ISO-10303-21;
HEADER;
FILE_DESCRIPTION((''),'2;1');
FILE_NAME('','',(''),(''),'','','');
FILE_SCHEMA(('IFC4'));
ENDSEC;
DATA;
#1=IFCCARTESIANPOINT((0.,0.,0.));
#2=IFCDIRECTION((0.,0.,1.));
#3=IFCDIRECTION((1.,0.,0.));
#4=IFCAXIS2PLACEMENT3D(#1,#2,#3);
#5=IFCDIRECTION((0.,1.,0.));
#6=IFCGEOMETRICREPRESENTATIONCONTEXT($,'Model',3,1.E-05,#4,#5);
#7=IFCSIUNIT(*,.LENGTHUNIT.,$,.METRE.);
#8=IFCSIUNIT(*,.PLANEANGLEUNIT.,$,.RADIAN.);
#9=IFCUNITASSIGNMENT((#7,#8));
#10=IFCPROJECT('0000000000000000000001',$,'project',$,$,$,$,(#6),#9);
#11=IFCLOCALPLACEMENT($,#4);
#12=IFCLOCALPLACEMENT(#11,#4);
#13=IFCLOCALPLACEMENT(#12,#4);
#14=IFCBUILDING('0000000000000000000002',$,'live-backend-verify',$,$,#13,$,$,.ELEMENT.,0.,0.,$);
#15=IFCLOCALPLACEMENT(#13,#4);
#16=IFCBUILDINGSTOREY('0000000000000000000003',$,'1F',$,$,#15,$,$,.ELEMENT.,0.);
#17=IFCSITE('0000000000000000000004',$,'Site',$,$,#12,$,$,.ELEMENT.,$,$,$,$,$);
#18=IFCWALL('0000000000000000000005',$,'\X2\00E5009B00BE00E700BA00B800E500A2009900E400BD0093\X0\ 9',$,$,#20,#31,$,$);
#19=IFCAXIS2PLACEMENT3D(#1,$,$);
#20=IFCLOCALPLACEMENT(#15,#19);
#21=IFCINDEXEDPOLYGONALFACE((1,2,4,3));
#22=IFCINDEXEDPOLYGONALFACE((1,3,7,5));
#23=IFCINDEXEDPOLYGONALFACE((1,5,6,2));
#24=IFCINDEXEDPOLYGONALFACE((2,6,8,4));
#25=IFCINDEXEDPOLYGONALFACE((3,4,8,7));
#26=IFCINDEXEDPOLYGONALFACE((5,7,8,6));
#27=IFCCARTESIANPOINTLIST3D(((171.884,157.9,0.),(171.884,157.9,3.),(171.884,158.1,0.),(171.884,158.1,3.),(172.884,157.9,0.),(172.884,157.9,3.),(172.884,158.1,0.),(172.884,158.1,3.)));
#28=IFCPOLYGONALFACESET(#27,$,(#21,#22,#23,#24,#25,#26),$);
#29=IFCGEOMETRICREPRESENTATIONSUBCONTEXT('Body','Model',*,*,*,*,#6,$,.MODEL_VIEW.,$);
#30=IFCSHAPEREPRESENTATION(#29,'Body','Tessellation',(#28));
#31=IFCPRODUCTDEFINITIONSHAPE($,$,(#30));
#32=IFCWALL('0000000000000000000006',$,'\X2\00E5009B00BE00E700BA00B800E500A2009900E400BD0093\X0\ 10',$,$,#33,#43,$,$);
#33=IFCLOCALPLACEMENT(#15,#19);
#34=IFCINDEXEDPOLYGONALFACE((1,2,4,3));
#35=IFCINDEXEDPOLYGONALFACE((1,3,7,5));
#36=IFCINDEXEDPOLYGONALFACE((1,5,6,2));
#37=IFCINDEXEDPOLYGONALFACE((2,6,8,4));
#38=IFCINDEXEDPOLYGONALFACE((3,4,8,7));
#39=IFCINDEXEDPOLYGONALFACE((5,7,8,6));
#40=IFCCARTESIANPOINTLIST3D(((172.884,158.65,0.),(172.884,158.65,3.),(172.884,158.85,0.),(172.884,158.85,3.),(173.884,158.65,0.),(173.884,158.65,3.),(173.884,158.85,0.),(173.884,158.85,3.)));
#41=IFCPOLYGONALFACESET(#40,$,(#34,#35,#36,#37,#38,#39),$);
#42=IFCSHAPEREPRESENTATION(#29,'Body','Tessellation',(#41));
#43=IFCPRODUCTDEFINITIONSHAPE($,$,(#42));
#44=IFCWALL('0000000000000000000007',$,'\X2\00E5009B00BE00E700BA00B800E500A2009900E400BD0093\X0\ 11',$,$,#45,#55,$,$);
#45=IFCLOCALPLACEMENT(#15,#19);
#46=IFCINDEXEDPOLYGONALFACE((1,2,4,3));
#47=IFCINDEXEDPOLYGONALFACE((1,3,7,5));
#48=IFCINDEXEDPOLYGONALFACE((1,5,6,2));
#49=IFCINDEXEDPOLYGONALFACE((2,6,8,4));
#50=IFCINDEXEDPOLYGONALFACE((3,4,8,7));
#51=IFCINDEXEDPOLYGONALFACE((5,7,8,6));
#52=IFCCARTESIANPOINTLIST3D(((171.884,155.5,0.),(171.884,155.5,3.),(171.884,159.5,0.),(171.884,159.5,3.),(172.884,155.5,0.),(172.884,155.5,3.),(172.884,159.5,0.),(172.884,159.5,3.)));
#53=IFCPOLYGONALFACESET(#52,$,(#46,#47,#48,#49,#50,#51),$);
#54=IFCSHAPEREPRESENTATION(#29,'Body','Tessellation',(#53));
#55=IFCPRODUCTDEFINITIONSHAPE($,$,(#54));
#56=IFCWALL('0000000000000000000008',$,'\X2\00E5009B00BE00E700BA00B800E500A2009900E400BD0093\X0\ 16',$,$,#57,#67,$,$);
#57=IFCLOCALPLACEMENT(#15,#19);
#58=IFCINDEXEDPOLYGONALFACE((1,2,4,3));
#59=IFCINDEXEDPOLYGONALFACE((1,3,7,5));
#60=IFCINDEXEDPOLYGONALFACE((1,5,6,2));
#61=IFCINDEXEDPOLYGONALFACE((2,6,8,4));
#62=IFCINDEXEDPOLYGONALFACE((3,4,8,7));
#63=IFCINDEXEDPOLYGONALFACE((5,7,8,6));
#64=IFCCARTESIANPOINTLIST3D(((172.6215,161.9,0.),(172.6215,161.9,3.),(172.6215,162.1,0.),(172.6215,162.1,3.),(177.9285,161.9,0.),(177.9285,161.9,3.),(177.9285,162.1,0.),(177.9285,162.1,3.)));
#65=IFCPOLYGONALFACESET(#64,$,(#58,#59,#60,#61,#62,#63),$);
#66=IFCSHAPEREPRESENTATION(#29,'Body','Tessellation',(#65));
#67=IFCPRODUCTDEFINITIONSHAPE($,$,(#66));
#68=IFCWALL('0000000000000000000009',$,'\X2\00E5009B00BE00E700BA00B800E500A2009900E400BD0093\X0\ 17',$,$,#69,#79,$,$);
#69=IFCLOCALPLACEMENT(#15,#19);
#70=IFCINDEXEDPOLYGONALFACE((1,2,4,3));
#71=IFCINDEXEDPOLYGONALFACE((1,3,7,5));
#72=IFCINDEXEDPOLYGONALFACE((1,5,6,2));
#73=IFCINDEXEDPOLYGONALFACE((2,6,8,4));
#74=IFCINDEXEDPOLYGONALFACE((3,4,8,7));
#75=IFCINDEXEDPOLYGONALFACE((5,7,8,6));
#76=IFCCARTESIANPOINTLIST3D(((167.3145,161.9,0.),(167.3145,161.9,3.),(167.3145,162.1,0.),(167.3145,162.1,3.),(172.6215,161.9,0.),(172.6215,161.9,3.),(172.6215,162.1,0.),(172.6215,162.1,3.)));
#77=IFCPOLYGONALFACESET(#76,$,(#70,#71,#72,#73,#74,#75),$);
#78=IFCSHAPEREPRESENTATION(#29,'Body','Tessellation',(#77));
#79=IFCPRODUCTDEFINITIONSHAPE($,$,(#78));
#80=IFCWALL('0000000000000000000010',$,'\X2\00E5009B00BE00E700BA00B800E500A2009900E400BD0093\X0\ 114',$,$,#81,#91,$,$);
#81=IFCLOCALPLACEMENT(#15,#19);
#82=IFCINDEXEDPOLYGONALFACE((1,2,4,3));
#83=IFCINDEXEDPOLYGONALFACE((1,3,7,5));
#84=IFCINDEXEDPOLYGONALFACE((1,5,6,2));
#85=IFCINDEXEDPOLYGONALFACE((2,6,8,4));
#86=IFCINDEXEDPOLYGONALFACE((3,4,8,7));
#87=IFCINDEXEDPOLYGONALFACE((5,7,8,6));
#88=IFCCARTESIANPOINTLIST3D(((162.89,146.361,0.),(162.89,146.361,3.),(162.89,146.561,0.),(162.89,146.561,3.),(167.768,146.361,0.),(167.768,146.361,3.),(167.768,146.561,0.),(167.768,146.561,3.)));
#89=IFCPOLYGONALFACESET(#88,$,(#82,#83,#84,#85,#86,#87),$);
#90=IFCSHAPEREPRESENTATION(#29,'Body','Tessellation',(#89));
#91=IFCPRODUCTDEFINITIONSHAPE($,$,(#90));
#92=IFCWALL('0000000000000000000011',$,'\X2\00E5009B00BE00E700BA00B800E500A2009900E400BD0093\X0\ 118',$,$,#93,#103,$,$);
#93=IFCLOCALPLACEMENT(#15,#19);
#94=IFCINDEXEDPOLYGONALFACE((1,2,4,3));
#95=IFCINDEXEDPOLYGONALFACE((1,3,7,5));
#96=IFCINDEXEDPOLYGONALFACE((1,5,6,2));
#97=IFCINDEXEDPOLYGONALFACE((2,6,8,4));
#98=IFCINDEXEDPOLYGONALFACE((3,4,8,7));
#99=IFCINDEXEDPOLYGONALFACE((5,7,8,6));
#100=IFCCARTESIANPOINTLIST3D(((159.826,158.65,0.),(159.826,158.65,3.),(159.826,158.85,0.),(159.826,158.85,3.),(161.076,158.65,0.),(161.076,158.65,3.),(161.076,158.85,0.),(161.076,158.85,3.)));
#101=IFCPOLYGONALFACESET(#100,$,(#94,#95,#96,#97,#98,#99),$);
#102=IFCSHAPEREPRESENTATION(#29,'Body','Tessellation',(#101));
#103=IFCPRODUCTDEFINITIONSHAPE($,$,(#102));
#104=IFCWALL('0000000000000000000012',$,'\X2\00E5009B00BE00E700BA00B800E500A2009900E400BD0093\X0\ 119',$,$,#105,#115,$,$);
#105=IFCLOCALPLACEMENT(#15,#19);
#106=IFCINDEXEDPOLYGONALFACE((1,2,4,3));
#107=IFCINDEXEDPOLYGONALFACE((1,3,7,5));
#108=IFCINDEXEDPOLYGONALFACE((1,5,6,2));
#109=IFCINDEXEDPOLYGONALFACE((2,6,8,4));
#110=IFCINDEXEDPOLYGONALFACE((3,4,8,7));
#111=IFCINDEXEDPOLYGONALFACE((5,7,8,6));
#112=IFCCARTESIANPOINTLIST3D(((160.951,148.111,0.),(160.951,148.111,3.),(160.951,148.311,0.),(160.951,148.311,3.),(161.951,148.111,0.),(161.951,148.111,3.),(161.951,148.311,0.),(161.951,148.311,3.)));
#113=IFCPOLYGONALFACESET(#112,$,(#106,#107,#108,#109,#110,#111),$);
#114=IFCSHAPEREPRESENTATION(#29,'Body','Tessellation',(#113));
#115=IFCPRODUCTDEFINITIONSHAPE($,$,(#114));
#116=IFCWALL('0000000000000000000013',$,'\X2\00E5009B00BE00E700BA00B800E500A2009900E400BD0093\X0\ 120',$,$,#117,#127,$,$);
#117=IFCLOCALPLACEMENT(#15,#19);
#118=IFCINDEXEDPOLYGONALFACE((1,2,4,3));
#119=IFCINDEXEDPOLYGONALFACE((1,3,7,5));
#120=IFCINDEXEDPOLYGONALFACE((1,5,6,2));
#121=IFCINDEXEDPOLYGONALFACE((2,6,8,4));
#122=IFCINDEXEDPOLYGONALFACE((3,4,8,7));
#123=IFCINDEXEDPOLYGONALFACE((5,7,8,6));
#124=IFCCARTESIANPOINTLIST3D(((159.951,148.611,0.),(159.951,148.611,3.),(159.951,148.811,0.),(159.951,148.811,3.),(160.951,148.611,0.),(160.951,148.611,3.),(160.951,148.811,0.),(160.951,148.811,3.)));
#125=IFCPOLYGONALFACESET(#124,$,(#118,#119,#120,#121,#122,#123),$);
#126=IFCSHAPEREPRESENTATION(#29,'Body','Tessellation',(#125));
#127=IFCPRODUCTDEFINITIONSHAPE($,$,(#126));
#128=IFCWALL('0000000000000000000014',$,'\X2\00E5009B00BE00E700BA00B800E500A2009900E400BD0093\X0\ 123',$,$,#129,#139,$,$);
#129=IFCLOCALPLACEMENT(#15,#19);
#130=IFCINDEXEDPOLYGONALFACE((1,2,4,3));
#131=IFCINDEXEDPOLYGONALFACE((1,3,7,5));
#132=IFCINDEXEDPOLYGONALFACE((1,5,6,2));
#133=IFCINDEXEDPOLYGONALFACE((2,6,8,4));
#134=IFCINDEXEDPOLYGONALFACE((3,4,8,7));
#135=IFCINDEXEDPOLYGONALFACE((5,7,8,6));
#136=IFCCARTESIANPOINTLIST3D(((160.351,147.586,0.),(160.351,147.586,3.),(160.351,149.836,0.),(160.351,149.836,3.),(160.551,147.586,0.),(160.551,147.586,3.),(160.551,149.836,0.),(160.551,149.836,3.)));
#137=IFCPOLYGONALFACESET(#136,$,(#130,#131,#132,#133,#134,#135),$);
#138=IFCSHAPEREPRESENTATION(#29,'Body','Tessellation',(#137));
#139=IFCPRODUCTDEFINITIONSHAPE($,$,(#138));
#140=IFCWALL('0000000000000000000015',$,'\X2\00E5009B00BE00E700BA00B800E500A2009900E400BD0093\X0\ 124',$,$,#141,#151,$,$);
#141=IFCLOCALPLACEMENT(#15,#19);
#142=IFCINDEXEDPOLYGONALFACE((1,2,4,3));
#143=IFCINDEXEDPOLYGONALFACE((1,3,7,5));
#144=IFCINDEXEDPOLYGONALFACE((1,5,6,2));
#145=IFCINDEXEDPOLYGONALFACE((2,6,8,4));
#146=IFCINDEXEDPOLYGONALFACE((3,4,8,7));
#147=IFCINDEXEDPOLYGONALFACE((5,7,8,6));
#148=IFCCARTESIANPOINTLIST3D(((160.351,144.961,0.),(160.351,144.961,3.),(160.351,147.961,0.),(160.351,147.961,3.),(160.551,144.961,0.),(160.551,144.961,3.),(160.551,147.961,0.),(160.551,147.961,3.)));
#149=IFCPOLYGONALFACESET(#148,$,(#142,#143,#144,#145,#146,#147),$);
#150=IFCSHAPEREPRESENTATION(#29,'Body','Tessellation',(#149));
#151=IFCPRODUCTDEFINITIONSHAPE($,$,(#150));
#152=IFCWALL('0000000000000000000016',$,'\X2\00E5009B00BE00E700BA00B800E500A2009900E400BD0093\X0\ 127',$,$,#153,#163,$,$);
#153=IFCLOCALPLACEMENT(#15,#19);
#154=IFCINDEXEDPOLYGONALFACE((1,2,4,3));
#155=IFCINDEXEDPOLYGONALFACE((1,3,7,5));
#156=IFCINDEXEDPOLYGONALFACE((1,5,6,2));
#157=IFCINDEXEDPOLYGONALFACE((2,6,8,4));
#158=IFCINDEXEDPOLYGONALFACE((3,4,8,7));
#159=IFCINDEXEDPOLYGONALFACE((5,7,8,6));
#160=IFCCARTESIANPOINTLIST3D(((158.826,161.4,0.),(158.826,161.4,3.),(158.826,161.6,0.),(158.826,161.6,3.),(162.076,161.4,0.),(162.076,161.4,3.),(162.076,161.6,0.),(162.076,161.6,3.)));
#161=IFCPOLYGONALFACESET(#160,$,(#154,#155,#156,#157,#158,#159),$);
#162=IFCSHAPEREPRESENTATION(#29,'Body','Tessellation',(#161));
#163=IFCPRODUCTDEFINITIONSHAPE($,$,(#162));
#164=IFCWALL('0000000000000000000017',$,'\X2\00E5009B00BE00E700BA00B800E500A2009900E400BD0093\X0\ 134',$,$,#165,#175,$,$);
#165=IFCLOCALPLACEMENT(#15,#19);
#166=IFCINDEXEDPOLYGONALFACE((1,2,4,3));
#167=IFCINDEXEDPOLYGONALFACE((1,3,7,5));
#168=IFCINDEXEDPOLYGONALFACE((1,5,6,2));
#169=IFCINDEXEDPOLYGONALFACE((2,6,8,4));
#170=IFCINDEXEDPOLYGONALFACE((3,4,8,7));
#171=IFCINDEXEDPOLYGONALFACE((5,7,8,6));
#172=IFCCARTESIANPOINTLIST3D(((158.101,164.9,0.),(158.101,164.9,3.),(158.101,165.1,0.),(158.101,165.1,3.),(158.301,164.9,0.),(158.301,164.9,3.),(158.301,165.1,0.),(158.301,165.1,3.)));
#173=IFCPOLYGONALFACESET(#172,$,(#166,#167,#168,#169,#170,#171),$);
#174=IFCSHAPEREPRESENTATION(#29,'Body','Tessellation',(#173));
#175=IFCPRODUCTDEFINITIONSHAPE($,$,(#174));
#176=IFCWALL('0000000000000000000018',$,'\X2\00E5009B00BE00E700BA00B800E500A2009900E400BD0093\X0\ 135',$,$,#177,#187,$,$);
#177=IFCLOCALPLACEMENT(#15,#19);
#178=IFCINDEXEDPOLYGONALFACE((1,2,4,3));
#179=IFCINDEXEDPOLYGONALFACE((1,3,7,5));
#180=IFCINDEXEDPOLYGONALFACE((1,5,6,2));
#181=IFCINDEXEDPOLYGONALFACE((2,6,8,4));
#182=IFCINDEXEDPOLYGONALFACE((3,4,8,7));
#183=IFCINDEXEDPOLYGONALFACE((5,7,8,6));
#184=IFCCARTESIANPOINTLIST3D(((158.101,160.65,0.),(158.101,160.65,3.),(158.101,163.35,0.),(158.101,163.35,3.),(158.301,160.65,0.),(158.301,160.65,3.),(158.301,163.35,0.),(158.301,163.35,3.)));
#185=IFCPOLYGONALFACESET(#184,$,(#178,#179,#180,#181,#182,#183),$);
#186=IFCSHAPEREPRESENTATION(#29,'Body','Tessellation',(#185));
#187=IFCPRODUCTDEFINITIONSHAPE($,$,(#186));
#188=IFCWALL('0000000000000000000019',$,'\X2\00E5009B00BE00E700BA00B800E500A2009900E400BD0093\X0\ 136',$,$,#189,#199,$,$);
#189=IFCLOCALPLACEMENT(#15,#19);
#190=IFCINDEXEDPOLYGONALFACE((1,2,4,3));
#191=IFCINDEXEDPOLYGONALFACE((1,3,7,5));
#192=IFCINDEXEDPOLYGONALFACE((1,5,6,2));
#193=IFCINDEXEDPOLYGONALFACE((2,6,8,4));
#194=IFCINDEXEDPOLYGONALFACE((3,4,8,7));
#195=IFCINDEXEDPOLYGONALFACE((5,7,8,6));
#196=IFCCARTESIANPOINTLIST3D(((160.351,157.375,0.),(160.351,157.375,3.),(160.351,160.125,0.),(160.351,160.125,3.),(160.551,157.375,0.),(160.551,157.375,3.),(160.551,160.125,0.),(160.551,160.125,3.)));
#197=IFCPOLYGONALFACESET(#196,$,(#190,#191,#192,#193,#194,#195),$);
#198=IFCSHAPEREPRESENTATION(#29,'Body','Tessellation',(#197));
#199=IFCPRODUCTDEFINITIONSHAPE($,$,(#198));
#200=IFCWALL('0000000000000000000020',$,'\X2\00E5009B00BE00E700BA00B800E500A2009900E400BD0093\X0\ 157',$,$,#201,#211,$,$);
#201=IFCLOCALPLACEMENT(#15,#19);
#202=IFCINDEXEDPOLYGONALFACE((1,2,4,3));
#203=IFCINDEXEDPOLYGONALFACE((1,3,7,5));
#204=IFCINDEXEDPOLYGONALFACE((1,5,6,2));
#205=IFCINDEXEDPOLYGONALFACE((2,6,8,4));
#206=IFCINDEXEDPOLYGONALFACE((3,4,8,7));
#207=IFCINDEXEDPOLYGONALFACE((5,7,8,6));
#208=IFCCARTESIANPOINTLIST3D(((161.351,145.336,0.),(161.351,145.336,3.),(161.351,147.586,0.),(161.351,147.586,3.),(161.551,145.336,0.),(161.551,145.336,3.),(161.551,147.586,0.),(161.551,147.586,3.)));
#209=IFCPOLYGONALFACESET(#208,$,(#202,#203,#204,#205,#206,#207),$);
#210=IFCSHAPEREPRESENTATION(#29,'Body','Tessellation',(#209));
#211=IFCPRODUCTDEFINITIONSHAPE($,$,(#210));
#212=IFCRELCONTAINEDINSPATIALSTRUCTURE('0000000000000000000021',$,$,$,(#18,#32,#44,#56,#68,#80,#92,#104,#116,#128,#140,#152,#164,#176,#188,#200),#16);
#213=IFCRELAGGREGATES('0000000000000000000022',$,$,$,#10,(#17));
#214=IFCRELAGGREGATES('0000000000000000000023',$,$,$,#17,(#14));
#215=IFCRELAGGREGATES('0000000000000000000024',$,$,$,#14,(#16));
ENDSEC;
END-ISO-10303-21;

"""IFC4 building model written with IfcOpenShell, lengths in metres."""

from ifc_helpers import new_model, si_unit, direction, frame, frame_2d, origin_with_axes, place, context, subcontext, project, spatial, rectangle, extrude, element, save


model = new_model("IFC4")

# Units and contexts
model_context = context("Model", 3, precision=1e-05, world=origin_with_axes(), true_north=direction((0.0, 1.0, 0.0)))
body_context = subcontext(model_context, "Body", "Model", "MODEL_VIEW")
ifc_project = project(units=[si_unit("LENGTHUNIT", "METRE"), si_unit("PLANEANGLEUNIT", "RADIAN")], contexts=[model_context])

# Site, building, storey
placement = place(None, origin_with_axes())
site_placement = place(placement, origin_with_axes())
site = spatial("IfcSite", under=ifc_project, at=site_placement, Name="Site", CompositionType="ELEMENT")
building_placement = place(site_placement, origin_with_axes())
building = spatial("IfcBuilding", under=site, at=building_placement, Name="live-backend-verify", CompositionType="ELEMENT", ElevationOfRefHeight=0.0, ElevationOfTerrain=0.0)
storey_placement = place(building_placement, origin_with_axes())
storey = spatial("IfcBuildingStorey", under=building, at=storey_placement, Name="1F", CompositionType="ELEMENT", Elevation=0.0)

# Walls
for number, where, z_axis, x_axis, name in (
    (1, (172.384, 158.0, 0.0), (0.0, 0.0, 1.0), (1.0, 0.0, 0.0), "å\u009b¾çº¸å¢\u0099ä½\u0093 9"),
    (2, (173.384, 158.75, 0.0), (0.0, 0.0, 1.0), (-1.0, 0.0, 0.0), "å\u009b¾çº¸å¢\u0099ä½\u0093 10"),
):
    element("IfcWall", number, at=place(storey_placement, frame(where, z_axis=z_axis, x_axis=x_axis)), inside=storey, Name=name, context=body_context, shape_type="SweptSolid", body=[
        extrude(rectangle(XDim=1.0, YDim=0.2, at=frame_2d((0.0, 0.0), x_axis=(1.0, 0.0, 0.0))), frame((0.0, 0.0, 0.0), z_axis=(0.0, 0.0, 1.0)), (0.0, 0.0, 1.0), 3.0),
    ])
wall_1_placement = place(storey_placement, frame((172.384, 157.5, 0.0), z_axis=(0.0, 0.0, 1.0), x_axis=(1.0, 0.0, 0.0)))
element("IfcWall", 3, at=wall_1_placement, inside=storey, Name="å\u009b¾çº¸å¢\u0099ä½\u0093 11", context=body_context, shape_type="SweptSolid", body=[
    extrude(rectangle(XDim=1.0, YDim=4.0, at=frame_2d((0.0, 0.0), x_axis=(1.0, 0.0, 0.0))), frame((0.0, 0.0, 0.0), z_axis=(0.0, 0.0, 1.0)), (0.0, 0.0, 1.0), 3.0),
])
for number, where, z_axis, x_axis, name in (
    (4, (175.275, 162.0, 0.0), (0.0, 0.0, 1.0), (-1.0, 0.0, 0.0), "å\u009b¾çº¸å¢\u0099ä½\u0093 16"),
    (5, (169.968, 162.0, 0.0), (0.0, 0.0, 1.0), (1.0, 0.0, 0.0), "å\u009b¾çº¸å¢\u0099ä½\u0093 17"),
):
    element("IfcWall", number, at=place(storey_placement, frame(where, z_axis=z_axis, x_axis=x_axis)), inside=storey, Name=name, context=body_context, shape_type="SweptSolid", body=[
        extrude(rectangle(XDim=5.307, YDim=0.2, at=frame_2d((0.0, 0.0), x_axis=(1.0, 0.0, 0.0))), frame((0.0, 0.0, 0.0), z_axis=(0.0, 0.0, 1.0)), (0.0, 0.0, 1.0), 3.0),
    ])
wall_2_placement = place(storey_placement, frame((165.329, 146.461, 0.0), z_axis=(0.0, 0.0, 1.0), x_axis=(-1.0, 0.0, 0.0)))
element("IfcWall", 6, at=wall_2_placement, inside=storey, Name="å\u009b¾çº¸å¢\u0099ä½\u0093 114", context=body_context, shape_type="SweptSolid", body=[
    extrude(rectangle(XDim=4.878, YDim=0.2, at=frame_2d((0.0, 0.0), x_axis=(1.0, 0.0, 0.0))), frame((0.0, 0.0, 0.0), z_axis=(0.0, 0.0, 1.0)), (0.0, 0.0, 1.0), 3.0),
])
wall_3_placement = place(storey_placement, frame((160.451, 158.75, 0.0), z_axis=(0.0, 0.0, 1.0), x_axis=(1.0, 0.0, 0.0)))
element("IfcWall", 7, at=wall_3_placement, inside=storey, Name="å\u009b¾çº¸å¢\u0099ä½\u0093 118", context=body_context, shape_type="SweptSolid", body=[
    extrude(rectangle(XDim=1.25, YDim=0.2, at=frame_2d((0.0, 0.0), x_axis=(1.0, 0.0, 0.0))), frame((0.0, 0.0, 0.0), z_axis=(0.0, 0.0, 1.0)), (0.0, 0.0, 1.0), 3.0),
])
for number, where, z_axis, x_axis, name in (
    (8, (161.451, 148.211, 0.0), (0.0, 0.0, 1.0), (-1.0, 0.0, 0.0), "å\u009b¾çº¸å¢\u0099ä½\u0093 119"),
    (9, (160.451, 148.711, 0.0), (0.0, 0.0, 1.0), (1.0, 0.0, 0.0), "å\u009b¾çº¸å¢\u0099ä½\u0093 120"),
):
    element("IfcWall", number, at=place(storey_placement, frame(where, z_axis=z_axis, x_axis=x_axis)), inside=storey, Name=name, context=body_context, shape_type="SweptSolid", body=[
        extrude(rectangle(XDim=1.0, YDim=0.2, at=frame_2d((0.0, 0.0), x_axis=(1.0, 0.0, 0.0))), frame((0.0, 0.0, 0.0), z_axis=(0.0, 0.0, 1.0)), (0.0, 0.0, 1.0), 3.0),
    ])
wall_4_placement = place(storey_placement, frame((160.451, 148.711, 0.0), z_axis=(0.0, 0.0, 1.0), x_axis=(0.0, -1.0, 0.0)))
element("IfcWall", 10, at=wall_4_placement, inside=storey, Name="å\u009b¾çº¸å¢\u0099ä½\u0093 123", context=body_context, shape_type="SweptSolid", body=[
    extrude(rectangle(XDim=2.25, YDim=0.2, at=frame_2d((0.0, 0.0), x_axis=(1.0, 0.0, 0.0))), frame((0.0, 0.0, 0.0), z_axis=(0.0, 0.0, 1.0)), (0.0, 0.0, 1.0), 3.0),
])
wall_5_placement = place(storey_placement, frame((160.451, 146.461, 0.0), z_axis=(0.0, 0.0, 1.0), x_axis=(0.0, -1.0, 0.0)))
element("IfcWall", 11, at=wall_5_placement, inside=storey, Name="å\u009b¾çº¸å¢\u0099ä½\u0093 124", context=body_context, shape_type="SweptSolid", body=[
    extrude(rectangle(XDim=3.0, YDim=0.2, at=frame_2d((0.0, 0.0), x_axis=(1.0, 0.0, 0.0))), frame((0.0, 0.0, 0.0), z_axis=(0.0, 0.0, 1.0)), (0.0, 0.0, 1.0), 3.0),
])
wall_6_placement = place(storey_placement, frame((160.451, 161.5, 0.0), z_axis=(0.0, 0.0, 1.0), x_axis=(-1.0, 0.0, 0.0)))
element("IfcWall", 12, at=wall_6_placement, inside=storey, Name="å\u009b¾çº¸å¢\u0099ä½\u0093 127", context=body_context, shape_type="SweptSolid", body=[
    extrude(rectangle(XDim=3.25, YDim=0.2, at=frame_2d((0.0, 0.0), x_axis=(1.0, 0.0, 0.0))), frame((0.0, 0.0, 0.0), z_axis=(0.0, 0.0, 1.0)), (0.0, 0.0, 1.0), 3.0),
])
wall_7_placement = place(storey_placement, frame((158.201, 165.0, 0.0), z_axis=(0.0, 0.0, 1.0), x_axis=(1.0, 0.0, 0.0)))
element("IfcWall", 13, at=wall_7_placement, inside=storey, Name="å\u009b¾çº¸å¢\u0099ä½\u0093 134", context=body_context, shape_type="SweptSolid", body=[
    extrude(rectangle(XDim=0.2, YDim=0.2, at=frame_2d((0.0, 0.0), x_axis=(1.0, 0.0, 0.0))), frame((0.0, 0.0, 0.0), z_axis=(0.0, 0.0, 1.0)), (0.0, 0.0, 1.0), 3.0),
])
wall_8_placement = place(storey_placement, frame((158.201, 162.0, 0.0), z_axis=(0.0, 0.0, 1.0), x_axis=(0.0, 1.0, 0.0)))
element("IfcWall", 14, at=wall_8_placement, inside=storey, Name="å\u009b¾çº¸å¢\u0099ä½\u0093 135", context=body_context, shape_type="SweptSolid", body=[
    extrude(rectangle(XDim=2.7, YDim=0.2, at=frame_2d((0.0, 0.0), x_axis=(1.0, 0.0, 0.0))), frame((0.0, 0.0, 0.0), z_axis=(0.0, 0.0, 1.0)), (0.0, 0.0, 1.0), 3.0),
])
wall_9_placement = place(storey_placement, frame((160.451, 158.75, 0.0), z_axis=(0.0, 0.0, 1.0), x_axis=(0.0, 1.0, 0.0)))
element("IfcWall", 15, at=wall_9_placement, inside=storey, Name="å\u009b¾çº¸å¢\u0099ä½\u0093 136", context=body_context, shape_type="SweptSolid", body=[
    extrude(rectangle(XDim=2.75, YDim=0.2, at=frame_2d((0.0, 0.0), x_axis=(1.0, 0.0, 0.0))), frame((0.0, 0.0, 0.0), z_axis=(0.0, 0.0, 1.0)), (0.0, 0.0, 1.0), 3.0),
])
wall_10_placement = place(storey_placement, frame((161.451, 146.461, 0.0), z_axis=(0.0, 0.0, 1.0), x_axis=(0.0, 1.0, 0.0)))
element("IfcWall", 16, at=wall_10_placement, inside=storey, Name="å\u009b¾çº¸å¢\u0099ä½\u0093 157", context=body_context, shape_type="SweptSolid", body=[
    extrude(rectangle(XDim=2.25, YDim=0.2, at=frame_2d((0.0, 0.0), x_axis=(1.0, 0.0, 0.0))), frame((0.0, 0.0, 0.0), z_axis=(0.0, 0.0, 1.0)), (0.0, 0.0, 1.0), 3.0),
])

save(model, "model.ifc")
